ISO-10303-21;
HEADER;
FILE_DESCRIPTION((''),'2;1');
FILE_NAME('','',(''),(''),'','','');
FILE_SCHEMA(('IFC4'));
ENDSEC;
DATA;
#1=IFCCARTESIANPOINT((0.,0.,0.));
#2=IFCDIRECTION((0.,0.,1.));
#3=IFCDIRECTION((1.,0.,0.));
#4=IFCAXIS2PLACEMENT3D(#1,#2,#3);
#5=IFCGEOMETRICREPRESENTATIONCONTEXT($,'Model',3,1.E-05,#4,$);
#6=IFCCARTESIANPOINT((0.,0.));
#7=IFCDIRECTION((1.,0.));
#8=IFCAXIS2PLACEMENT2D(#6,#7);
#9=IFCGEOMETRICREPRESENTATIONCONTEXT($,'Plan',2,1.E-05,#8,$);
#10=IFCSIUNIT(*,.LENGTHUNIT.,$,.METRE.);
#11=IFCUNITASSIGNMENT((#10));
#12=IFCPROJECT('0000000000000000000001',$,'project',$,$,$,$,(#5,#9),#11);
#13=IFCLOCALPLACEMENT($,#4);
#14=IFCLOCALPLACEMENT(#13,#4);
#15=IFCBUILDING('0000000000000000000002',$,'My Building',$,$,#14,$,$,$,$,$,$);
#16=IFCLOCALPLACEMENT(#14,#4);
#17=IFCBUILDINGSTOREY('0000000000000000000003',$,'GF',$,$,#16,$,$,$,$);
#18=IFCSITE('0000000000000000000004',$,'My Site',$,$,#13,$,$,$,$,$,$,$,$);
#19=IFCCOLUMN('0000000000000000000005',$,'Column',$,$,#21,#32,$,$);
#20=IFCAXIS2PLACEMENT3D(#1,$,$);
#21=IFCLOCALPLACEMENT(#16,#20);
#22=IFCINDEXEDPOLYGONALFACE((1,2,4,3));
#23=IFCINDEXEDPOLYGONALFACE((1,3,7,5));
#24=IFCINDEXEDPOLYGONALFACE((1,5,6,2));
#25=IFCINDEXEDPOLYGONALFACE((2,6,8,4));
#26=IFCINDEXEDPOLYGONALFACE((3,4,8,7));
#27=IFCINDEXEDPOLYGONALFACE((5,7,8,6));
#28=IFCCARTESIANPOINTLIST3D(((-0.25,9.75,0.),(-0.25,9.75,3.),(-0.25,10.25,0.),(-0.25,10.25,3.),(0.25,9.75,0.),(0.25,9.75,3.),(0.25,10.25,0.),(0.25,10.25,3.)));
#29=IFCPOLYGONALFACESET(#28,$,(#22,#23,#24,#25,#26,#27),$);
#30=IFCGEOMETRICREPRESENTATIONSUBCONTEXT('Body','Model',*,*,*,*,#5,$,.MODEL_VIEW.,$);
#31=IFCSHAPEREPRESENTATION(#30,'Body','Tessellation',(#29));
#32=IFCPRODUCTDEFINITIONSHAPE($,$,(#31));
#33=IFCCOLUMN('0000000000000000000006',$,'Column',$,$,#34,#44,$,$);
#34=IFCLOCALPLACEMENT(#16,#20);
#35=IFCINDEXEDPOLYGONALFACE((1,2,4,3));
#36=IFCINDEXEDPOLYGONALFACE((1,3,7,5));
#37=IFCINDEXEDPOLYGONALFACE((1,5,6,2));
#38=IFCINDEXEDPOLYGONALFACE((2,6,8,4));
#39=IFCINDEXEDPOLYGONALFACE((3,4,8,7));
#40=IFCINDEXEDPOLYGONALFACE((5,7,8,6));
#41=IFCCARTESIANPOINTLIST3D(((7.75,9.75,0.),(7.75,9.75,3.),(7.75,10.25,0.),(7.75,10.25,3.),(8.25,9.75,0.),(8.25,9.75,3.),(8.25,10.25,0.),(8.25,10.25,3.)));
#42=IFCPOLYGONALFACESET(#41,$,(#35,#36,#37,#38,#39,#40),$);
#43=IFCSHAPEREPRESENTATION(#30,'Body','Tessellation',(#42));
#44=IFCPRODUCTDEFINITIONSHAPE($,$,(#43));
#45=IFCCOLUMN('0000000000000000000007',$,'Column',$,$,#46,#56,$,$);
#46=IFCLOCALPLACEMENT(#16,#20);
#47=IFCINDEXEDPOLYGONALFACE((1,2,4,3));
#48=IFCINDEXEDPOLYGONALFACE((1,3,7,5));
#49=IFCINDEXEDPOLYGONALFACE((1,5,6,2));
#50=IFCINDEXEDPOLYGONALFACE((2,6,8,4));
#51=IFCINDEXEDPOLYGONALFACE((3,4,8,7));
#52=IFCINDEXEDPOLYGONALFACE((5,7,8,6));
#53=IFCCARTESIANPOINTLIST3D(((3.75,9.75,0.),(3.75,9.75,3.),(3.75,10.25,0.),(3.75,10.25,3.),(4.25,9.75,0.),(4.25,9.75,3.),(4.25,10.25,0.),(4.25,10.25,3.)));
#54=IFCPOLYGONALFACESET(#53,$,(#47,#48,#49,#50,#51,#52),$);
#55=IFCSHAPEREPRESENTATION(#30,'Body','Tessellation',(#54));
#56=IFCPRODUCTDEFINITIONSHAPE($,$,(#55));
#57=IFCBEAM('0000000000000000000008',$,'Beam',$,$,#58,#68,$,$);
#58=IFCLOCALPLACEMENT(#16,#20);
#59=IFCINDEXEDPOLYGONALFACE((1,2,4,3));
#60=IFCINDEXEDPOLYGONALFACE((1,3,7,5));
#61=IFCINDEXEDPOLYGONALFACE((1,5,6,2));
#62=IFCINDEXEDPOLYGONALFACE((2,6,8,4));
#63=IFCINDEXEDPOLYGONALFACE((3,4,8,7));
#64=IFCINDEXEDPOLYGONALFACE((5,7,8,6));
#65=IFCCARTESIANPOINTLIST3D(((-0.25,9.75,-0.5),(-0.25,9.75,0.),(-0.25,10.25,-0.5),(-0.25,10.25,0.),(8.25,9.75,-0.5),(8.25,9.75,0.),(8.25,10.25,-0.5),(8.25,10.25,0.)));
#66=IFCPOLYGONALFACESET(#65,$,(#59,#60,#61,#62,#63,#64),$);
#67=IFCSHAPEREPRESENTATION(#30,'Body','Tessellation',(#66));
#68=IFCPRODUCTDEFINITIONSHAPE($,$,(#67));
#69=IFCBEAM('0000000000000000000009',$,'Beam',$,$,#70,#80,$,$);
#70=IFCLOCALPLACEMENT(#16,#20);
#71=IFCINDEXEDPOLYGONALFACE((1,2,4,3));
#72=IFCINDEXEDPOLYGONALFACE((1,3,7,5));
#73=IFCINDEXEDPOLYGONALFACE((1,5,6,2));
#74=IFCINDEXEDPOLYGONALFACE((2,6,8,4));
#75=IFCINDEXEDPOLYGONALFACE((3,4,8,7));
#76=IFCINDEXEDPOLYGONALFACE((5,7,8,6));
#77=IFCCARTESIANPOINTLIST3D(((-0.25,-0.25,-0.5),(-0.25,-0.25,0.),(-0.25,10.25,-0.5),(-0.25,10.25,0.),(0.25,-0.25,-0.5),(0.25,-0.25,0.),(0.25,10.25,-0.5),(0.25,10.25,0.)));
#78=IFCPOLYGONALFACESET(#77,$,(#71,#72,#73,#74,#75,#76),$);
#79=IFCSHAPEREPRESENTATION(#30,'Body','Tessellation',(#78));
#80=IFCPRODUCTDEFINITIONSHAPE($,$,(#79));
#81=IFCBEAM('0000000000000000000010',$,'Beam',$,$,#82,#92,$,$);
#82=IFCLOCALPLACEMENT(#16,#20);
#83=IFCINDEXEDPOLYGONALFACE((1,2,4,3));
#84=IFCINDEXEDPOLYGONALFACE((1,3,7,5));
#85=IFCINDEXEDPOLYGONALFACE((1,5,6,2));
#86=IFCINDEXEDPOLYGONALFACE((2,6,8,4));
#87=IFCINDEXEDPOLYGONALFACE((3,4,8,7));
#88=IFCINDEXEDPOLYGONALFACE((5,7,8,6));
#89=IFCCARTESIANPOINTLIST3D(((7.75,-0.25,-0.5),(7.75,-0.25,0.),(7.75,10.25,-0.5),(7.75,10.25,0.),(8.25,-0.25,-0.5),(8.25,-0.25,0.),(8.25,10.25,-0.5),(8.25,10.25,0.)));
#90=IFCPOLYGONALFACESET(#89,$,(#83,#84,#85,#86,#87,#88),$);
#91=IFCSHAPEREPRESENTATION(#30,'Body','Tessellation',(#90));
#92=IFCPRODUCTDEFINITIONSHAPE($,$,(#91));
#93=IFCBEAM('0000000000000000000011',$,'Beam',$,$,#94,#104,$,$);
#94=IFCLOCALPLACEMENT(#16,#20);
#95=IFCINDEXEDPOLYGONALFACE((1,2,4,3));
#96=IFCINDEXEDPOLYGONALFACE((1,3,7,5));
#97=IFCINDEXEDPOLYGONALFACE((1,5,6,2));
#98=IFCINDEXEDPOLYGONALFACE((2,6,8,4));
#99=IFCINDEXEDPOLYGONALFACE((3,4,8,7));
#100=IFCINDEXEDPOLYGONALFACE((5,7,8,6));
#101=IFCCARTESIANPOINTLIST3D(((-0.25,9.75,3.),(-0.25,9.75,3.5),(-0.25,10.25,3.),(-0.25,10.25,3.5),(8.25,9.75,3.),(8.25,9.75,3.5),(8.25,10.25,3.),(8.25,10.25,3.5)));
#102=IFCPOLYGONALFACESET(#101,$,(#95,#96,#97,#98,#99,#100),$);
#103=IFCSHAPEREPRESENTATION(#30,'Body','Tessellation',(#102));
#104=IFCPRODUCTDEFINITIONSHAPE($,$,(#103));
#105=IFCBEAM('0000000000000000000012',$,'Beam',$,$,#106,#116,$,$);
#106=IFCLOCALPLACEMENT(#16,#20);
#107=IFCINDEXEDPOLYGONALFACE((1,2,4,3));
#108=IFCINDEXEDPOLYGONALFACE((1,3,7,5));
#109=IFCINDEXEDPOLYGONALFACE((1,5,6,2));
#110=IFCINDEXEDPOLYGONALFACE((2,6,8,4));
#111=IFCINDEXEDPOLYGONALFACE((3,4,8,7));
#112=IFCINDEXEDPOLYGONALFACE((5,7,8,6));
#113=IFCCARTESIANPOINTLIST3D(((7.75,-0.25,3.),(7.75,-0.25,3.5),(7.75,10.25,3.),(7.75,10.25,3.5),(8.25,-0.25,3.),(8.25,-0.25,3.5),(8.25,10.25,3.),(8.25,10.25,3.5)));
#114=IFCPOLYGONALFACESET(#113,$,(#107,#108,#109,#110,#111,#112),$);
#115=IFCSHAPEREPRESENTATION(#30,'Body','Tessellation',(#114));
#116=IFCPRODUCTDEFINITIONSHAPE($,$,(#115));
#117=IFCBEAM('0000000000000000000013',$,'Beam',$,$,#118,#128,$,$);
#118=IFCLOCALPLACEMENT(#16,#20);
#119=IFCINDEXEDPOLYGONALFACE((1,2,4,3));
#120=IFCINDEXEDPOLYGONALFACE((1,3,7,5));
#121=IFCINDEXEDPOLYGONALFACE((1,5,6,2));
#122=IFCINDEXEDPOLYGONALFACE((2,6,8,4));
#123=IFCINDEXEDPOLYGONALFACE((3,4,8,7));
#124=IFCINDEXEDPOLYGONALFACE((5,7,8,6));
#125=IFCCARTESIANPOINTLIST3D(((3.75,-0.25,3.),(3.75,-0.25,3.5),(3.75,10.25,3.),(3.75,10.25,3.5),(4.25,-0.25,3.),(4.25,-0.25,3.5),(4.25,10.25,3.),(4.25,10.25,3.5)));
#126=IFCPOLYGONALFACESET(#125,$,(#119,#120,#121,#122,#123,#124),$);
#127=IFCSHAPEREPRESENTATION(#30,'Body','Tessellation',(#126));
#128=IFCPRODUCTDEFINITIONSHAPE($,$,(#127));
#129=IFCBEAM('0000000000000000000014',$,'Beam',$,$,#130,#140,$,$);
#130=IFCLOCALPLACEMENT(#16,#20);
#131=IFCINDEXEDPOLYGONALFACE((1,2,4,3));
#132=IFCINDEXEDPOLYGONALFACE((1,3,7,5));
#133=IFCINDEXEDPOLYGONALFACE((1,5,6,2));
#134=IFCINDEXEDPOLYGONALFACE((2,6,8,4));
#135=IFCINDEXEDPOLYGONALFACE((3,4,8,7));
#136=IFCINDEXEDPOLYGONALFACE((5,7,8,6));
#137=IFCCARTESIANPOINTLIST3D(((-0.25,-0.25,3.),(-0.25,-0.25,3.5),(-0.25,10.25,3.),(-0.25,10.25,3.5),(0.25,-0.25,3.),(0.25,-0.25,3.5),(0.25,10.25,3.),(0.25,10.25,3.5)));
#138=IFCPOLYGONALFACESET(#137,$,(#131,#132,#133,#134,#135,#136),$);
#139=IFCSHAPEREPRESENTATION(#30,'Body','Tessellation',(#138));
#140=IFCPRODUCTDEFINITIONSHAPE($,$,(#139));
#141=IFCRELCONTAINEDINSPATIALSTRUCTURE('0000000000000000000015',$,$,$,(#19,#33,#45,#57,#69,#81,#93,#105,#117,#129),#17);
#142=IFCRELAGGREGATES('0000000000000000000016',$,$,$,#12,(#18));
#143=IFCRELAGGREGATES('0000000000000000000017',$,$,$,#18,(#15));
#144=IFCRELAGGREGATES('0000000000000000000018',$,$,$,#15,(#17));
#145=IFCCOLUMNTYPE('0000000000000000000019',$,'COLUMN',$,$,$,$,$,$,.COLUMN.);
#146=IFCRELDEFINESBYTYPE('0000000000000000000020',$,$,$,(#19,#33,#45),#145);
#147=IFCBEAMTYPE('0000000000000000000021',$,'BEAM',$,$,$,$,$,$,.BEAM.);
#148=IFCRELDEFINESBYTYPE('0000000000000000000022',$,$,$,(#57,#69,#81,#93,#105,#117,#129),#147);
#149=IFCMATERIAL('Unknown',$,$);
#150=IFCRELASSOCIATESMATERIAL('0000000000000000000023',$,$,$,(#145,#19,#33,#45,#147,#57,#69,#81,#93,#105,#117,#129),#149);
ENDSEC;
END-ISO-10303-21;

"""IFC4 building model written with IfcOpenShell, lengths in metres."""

from ifc_helpers import new_model, si_unit, frame, origin_with_axes, origin_2d_with_axis, place, context, subcontext, project, spatial, rectangle, extrude, material, material_profile, profile_set, profile_usage, type_object, element, save


model = new_model("IFC4")

# Units and contexts
model_context = context("Model", 3, precision=1e-05, world=origin_with_axes())
plan_context = context("Plan", 2, precision=1e-05, world=origin_2d_with_axis())
body_context_1 = subcontext(model_context, "Body", "Model", "MODEL_VIEW")
ifc_project = project(units=[si_unit("LENGTHUNIT", "METRE")], contexts=[model_context, plan_context])

# Site, building, storey
site_placement = place(None, origin_with_axes())
site = spatial("IfcSite", under=ifc_project, at=site_placement, Name="My Site")
building_placement = place(site_placement, origin_with_axes())
building = spatial("IfcBuilding", under=site, at=building_placement, Name="My Building")
storey_placement = place(building_placement, origin_with_axes())
storey = spatial("IfcBuildingStorey", under=building, at=storey_placement, Name="GF")

# Columns
ifc_material = material(Name="Unknown")
ifc_material_profile_1 = material_profile(ifc_material, rectangle(XDim=0.5, YDim=0.5))
ifc_profile_set_1 = profile_set([ifc_material_profile_1])
ifc_profile_usage_1 = profile_usage(ifc_profile_set_1, cardinal=5)
column_type = type_object("IfcColumnType", Name="COLUMN", PredefinedType="COLUMN", material=ifc_profile_set_1)
column_1_placement = place(storey_placement, frame((0.0, 10.0, 0.0), z_axis=(0.0, 0.0, 1.0), x_axis=(1.0, 0.0, 0.0)))
element("IfcColumn", 1, at=column_1_placement, inside=storey, type_object=column_type, material=ifc_profile_usage_1, Name="Column", context=body_context_1, shape_type="SweptSolid", body=[
    extrude(rectangle(XDim=0.5, YDim=0.5), origin_with_axes(), (0.0, 0.0, 1.0), 3.0),
])
ifc_profile_usage_2 = profile_usage(ifc_profile_set_1, cardinal=5)
column_2_placement = place(storey_placement, frame((8.0, 10.0, 0.0), z_axis=(0.0, 0.0, 1.0), x_axis=(1.0, 0.0, 0.0)))
element("IfcColumn", 2, at=column_2_placement, inside=storey, type_object=column_type, material=ifc_profile_usage_2, Name="Column", context=body_context_1, shape_type="SweptSolid", body=[
    extrude(rectangle(XDim=0.5, YDim=0.5), origin_with_axes(), (0.0, 0.0, 1.0), 3.0),
])
ifc_profile_usage_3 = profile_usage(ifc_profile_set_1, cardinal=5)
column_3_placement = place(storey_placement, frame((4.0, 10.0, 0.0), z_axis=(0.0, 0.0, 1.0), x_axis=(1.0, 0.0, 0.0)))
element("IfcColumn", 3, at=column_3_placement, inside=storey, type_object=column_type, material=ifc_profile_usage_3, Name="Column", context=body_context_1, shape_type="SweptSolid", body=[
    extrude(rectangle(XDim=0.5, YDim=0.5), origin_with_axes(), (0.0, 0.0, 1.0), 3.0),
])

# Beams
ifc_material_profile_2 = material_profile(ifc_material, rectangle(XDim=0.5, YDim=0.5))
ifc_profile_set_2 = profile_set([ifc_material_profile_2])
ifc_profile_usage_4 = profile_usage(ifc_profile_set_2, cardinal=5)
beam_type = type_object("IfcBeamType", Name="BEAM", PredefinedType="BEAM", material=ifc_profile_set_2)
beam_1_placement = place(storey_placement, frame((-0.25, 10.0, -0.25), z_axis=(1.0, 0.0, 0.0), x_axis=(0.0, 1.0, 0.0)))
element("IfcBeam", 4, at=beam_1_placement, inside=storey, type_object=beam_type, material=ifc_profile_usage_4, Name="Beam", context=body_context_1, shape_type="SweptSolid", body=[
    extrude(rectangle(XDim=0.5, YDim=0.5), origin_with_axes(), (0.0, 0.0, 1.0), 8.5),
])
ifc_profile_usage_5 = profile_usage(ifc_profile_set_2, cardinal=5)
beam_2_placement = place(storey_placement, frame((0.0, 10.25, -0.25), z_axis=(0.0, -1.0, 0.0), x_axis=(1.0, 0.0, 0.0)))
element("IfcBeam", 5, at=beam_2_placement, inside=storey, type_object=beam_type, material=ifc_profile_usage_5, Name="Beam", context=body_context_1, shape_type="SweptSolid", body=[
    extrude(rectangle(XDim=0.5, YDim=0.5), origin_with_axes(), (0.0, 0.0, 1.0), 10.5),
])
ifc_profile_usage_6 = profile_usage(ifc_profile_set_2, cardinal=5)
beam_3_placement = place(storey_placement, frame((8.0, 10.25, -0.25), z_axis=(0.0, -1.0, 0.0), x_axis=(1.0, 0.0, 0.0)))
element("IfcBeam", 6, at=beam_3_placement, inside=storey, type_object=beam_type, material=ifc_profile_usage_6, Name="Beam", context=body_context_1, shape_type="SweptSolid", body=[
    extrude(rectangle(XDim=0.5, YDim=0.5), origin_with_axes(), (0.0, 0.0, 1.0), 10.5),
])
ifc_profile_usage_7 = profile_usage(ifc_profile_set_2, cardinal=5)
beam_4_placement = place(storey_placement, frame((-0.25, 10.0, 3.25), z_axis=(1.0, 0.0, 0.0), x_axis=(0.0, 1.0, 0.0)))
element("IfcBeam", 7, at=beam_4_placement, inside=storey, type_object=beam_type, material=ifc_profile_usage_7, Name="Beam", context=body_context_1, shape_type="SweptSolid", body=[
    extrude(rectangle(XDim=0.5, YDim=0.5), origin_with_axes(), (0.0, 0.0, 1.0), 8.5),
])
ifc_profile_usage_8 = profile_usage(ifc_profile_set_2, cardinal=5)
beam_5_placement = place(storey_placement, frame((8.0, 10.25, 3.25), z_axis=(0.0, -1.0, 0.0), x_axis=(1.0, 0.0, 0.0)))
element("IfcBeam", 8, at=beam_5_placement, inside=storey, type_object=beam_type, material=ifc_profile_usage_8, Name="Beam", context=body_context_1, shape_type="SweptSolid", body=[
    extrude(rectangle(XDim=0.5, YDim=0.5), origin_with_axes(), (0.0, 0.0, 1.0), 10.5),
])
ifc_profile_usage_9 = profile_usage(ifc_profile_set_2, cardinal=5)
beam_6_placement = place(storey_placement, frame((4.0, 10.25, 3.25), z_axis=(0.0, -1.0, 0.0), x_axis=(1.0, 0.0, 0.0)))
element("IfcBeam", 9, at=beam_6_placement, inside=storey, type_object=beam_type, material=ifc_profile_usage_9, Name="Beam", context=body_context_1, shape_type="SweptSolid", body=[
    extrude(rectangle(XDim=0.5, YDim=0.5), origin_with_axes(), (0.0, 0.0, 1.0), 10.5),
])
ifc_profile_usage_10 = profile_usage(ifc_profile_set_2, cardinal=5)
beam_7_placement = place(storey_placement, frame((0.0, 10.25, 3.25), z_axis=(0.0, -1.0, 0.0), x_axis=(1.0, 0.0, 0.0)))
element("IfcBeam", 10, at=beam_7_placement, inside=storey, type_object=beam_type, material=ifc_profile_usage_10, Name="Beam", context=body_context_1, shape_type="SweptSolid", body=[
    extrude(rectangle(XDim=0.5, YDim=0.5), origin_with_axes(), (0.0, 0.0, 1.0), 10.5),
])

save(model, "model.ifc")
